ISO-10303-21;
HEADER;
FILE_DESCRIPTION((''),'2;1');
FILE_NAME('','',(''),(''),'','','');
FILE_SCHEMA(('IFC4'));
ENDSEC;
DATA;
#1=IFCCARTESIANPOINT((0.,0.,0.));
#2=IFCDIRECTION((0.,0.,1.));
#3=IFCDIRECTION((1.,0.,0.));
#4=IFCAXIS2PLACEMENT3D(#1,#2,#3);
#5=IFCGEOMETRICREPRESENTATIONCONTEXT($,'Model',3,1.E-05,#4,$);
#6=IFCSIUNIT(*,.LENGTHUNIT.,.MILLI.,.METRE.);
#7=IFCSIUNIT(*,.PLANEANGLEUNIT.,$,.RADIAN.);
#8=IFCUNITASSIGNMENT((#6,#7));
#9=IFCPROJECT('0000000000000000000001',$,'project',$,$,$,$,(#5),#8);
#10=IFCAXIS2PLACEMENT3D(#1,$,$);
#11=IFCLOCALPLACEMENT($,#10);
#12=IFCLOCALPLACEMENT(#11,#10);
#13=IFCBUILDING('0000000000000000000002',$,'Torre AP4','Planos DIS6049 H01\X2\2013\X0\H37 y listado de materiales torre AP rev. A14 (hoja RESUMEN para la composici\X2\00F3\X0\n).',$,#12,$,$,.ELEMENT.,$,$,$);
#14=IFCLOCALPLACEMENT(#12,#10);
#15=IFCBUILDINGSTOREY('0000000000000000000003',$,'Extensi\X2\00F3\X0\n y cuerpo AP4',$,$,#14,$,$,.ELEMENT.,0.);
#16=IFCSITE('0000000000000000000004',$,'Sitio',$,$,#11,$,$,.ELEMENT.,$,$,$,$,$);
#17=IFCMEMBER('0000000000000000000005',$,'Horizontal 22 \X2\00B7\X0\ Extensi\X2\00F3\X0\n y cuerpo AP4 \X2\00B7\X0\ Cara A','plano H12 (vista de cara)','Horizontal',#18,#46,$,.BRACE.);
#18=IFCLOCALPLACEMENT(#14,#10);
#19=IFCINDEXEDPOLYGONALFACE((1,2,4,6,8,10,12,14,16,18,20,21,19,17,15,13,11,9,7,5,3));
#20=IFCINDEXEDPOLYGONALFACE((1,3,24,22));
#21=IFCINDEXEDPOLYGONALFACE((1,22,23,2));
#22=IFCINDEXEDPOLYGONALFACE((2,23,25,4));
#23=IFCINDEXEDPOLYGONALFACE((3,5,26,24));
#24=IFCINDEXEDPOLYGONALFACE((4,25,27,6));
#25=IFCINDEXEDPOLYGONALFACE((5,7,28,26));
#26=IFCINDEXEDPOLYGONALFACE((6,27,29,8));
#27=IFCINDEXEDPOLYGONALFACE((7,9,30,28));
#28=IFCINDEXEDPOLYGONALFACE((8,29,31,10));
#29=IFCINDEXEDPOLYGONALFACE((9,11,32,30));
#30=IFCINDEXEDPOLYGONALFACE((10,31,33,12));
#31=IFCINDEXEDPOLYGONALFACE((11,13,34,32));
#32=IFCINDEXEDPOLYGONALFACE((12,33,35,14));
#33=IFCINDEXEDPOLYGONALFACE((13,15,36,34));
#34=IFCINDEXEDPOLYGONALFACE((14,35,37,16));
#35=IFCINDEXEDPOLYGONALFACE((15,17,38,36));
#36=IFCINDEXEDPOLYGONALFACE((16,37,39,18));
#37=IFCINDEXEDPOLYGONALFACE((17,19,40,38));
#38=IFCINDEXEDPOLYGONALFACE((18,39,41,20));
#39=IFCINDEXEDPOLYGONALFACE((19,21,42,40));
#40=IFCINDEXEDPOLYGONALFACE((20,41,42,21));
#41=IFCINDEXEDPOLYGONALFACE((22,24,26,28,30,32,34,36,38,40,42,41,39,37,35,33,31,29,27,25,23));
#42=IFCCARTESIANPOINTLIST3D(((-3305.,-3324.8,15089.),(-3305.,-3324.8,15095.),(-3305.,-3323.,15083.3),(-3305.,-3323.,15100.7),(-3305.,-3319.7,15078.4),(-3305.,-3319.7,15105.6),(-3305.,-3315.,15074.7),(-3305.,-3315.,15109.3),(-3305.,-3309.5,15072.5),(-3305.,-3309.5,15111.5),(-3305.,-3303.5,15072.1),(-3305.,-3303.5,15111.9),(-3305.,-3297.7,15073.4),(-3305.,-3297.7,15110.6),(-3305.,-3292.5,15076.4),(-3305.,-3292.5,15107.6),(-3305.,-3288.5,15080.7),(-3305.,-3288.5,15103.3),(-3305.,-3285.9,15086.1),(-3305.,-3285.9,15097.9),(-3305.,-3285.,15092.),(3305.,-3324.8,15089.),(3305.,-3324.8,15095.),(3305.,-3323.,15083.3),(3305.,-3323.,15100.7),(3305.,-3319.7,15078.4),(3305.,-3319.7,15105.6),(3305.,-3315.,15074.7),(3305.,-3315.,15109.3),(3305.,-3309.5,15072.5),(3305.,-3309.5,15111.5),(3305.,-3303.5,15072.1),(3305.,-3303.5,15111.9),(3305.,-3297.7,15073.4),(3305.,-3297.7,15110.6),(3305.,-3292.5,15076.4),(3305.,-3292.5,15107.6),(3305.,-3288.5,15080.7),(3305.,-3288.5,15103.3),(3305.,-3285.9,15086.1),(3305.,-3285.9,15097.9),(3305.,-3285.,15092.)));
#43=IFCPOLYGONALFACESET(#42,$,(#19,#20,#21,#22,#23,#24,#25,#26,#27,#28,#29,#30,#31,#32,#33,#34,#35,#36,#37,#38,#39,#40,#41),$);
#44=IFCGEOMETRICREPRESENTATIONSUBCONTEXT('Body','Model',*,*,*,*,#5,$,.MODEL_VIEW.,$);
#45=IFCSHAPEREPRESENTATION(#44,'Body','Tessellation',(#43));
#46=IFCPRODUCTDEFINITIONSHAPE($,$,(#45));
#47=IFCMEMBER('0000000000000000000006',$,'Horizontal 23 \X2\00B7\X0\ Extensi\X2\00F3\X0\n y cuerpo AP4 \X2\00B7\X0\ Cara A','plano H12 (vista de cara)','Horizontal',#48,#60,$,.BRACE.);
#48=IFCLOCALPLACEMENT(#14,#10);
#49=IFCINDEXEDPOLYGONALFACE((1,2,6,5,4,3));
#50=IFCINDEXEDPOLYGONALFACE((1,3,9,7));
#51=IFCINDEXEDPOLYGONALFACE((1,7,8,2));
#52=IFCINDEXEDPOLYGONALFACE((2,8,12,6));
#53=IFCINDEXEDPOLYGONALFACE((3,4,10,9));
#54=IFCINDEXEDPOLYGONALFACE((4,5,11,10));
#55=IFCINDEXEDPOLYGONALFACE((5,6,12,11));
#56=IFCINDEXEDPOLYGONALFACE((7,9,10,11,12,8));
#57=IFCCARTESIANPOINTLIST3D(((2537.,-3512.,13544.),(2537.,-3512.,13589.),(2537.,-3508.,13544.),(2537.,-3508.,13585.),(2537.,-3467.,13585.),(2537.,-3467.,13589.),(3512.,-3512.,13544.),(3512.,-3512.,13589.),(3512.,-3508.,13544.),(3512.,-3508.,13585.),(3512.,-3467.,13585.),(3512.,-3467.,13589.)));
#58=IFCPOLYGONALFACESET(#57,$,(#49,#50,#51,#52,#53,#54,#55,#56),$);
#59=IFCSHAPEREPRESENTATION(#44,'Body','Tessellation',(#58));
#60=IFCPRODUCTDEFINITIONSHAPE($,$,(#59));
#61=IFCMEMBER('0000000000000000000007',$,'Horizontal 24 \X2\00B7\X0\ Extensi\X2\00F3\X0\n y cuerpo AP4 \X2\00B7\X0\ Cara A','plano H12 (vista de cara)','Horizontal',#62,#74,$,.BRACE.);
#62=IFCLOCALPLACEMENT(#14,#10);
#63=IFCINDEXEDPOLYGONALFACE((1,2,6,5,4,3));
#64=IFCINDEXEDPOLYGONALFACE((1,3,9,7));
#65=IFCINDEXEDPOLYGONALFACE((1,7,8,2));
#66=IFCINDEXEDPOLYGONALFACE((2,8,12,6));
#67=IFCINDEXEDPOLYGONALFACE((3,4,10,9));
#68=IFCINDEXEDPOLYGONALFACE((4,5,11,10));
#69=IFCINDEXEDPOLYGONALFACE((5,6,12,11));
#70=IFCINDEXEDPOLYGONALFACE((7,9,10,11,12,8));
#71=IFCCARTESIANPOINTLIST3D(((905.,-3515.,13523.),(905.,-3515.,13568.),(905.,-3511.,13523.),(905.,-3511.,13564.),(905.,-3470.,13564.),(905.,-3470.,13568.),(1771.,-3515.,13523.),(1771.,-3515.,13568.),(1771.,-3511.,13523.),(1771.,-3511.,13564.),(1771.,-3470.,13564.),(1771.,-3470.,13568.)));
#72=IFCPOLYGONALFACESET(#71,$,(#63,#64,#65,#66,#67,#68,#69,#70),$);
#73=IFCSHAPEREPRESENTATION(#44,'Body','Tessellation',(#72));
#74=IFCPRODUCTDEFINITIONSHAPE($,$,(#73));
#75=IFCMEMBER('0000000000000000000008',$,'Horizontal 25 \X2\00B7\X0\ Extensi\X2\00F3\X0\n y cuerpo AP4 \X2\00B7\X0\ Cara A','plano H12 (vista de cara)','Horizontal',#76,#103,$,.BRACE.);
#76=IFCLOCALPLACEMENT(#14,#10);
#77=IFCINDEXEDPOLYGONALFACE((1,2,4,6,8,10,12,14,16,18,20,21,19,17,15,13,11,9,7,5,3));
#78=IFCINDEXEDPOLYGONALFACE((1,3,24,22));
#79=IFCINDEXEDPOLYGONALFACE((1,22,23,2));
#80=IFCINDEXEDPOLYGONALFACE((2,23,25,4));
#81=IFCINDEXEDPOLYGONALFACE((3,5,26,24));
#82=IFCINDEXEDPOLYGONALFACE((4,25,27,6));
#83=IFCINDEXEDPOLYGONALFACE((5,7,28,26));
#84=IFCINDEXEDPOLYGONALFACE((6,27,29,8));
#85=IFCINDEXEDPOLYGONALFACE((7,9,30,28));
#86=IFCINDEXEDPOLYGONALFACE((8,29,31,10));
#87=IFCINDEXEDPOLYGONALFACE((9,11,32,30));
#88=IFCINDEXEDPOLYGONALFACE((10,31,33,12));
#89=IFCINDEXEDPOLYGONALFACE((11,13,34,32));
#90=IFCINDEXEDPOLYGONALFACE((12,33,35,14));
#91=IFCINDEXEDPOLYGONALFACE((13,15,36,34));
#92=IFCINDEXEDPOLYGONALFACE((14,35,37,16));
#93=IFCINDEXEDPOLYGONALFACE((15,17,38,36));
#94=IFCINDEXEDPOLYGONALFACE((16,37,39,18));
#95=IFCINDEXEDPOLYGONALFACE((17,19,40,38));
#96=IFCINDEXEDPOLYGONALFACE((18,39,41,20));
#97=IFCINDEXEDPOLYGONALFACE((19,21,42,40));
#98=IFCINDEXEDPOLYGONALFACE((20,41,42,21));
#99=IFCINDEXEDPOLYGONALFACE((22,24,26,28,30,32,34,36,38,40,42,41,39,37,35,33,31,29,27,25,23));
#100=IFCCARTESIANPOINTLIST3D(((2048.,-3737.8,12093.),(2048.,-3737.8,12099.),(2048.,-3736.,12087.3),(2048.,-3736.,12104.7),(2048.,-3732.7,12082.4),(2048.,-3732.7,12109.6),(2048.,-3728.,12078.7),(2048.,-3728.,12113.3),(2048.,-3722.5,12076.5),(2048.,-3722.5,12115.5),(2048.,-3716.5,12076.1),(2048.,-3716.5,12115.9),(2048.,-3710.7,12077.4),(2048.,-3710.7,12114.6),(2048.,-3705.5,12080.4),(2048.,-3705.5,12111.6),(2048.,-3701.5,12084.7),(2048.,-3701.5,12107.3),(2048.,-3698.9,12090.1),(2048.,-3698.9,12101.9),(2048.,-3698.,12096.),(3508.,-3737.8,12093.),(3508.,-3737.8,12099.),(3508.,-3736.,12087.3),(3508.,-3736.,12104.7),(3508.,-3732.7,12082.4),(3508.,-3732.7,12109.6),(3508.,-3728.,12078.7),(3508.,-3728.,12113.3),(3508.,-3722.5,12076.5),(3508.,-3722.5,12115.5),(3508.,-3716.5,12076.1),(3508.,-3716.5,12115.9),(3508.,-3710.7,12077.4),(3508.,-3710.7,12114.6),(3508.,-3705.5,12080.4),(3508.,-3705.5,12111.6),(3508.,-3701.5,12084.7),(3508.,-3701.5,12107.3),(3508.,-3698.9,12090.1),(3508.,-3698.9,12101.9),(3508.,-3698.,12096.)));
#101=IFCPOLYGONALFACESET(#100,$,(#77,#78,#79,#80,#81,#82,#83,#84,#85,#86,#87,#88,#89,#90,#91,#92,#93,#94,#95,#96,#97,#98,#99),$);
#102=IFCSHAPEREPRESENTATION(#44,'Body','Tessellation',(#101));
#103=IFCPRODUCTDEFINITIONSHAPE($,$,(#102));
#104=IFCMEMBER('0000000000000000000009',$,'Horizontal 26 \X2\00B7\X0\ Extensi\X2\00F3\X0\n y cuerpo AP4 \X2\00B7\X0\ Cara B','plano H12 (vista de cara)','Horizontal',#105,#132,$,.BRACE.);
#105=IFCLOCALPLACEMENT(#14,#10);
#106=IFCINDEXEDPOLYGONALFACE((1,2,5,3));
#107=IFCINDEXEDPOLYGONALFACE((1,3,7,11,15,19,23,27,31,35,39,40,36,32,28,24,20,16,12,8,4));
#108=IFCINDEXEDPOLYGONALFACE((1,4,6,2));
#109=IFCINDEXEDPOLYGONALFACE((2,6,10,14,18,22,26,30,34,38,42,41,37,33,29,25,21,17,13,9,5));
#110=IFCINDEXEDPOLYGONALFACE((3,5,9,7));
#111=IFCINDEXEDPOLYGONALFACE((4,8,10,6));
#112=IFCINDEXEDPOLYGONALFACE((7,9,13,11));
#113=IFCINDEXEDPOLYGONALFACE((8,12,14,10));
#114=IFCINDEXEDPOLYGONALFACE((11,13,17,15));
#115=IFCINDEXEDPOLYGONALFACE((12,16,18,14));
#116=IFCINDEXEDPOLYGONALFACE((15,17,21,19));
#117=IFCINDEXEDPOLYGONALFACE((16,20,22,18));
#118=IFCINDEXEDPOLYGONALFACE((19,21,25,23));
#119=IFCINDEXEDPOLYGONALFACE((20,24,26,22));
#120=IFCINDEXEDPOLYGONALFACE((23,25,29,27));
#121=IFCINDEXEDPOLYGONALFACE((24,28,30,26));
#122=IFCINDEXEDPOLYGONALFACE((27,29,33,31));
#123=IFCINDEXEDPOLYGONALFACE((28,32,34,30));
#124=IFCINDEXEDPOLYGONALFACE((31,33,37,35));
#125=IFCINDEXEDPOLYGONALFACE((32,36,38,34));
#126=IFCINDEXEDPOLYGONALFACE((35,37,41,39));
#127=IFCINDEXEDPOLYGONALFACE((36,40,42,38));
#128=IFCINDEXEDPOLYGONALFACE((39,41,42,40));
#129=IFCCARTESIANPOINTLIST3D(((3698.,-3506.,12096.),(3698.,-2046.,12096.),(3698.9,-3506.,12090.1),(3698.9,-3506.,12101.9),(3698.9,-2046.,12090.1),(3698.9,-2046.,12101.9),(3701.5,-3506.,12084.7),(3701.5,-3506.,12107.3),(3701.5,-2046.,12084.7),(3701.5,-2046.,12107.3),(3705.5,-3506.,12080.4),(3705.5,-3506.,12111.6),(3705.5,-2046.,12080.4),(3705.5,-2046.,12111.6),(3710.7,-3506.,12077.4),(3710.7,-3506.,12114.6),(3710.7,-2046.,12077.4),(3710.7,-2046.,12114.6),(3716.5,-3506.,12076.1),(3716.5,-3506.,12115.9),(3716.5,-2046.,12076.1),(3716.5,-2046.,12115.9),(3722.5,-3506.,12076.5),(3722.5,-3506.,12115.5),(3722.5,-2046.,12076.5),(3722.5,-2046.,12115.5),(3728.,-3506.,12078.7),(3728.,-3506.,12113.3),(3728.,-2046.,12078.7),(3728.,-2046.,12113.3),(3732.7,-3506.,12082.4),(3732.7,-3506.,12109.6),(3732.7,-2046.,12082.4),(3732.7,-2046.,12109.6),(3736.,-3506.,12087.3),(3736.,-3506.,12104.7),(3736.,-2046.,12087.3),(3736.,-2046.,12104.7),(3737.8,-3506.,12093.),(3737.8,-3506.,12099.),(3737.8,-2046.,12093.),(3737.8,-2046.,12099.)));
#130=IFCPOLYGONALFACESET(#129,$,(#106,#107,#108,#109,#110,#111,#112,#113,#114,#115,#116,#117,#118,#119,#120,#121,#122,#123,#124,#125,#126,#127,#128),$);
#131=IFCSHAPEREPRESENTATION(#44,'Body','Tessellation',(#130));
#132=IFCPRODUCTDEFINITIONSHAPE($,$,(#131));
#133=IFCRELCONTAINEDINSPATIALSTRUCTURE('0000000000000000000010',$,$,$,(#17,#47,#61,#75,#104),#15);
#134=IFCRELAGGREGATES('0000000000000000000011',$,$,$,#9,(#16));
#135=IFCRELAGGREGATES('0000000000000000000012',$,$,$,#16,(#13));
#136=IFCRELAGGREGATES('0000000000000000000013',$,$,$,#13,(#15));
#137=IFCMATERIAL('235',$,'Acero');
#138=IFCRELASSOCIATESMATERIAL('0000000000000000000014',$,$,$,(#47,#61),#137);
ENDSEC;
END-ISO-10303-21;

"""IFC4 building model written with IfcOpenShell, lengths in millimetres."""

from ifc_helpers import new_model, si_unit, frame, frame_2d, origin, origin_with_axes, place, context, subcontext, project, spatial, circle, l_section, extrude, material, element, save


model = new_model("IFC4")

# Units and contexts
model_context = context("Model", 3, precision=1e-05, world=origin_with_axes())
body_context = subcontext(model_context, "Body", "Model", "MODEL_VIEW")
ifc_project = project(units=[si_unit("LENGTHUNIT", "METRE", prefix="MILLI"), si_unit("PLANEANGLEUNIT", "RADIAN")], contexts=[model_context])

# Site, building, storey
site_placement = place(None, origin())
site = spatial("IfcSite", under=ifc_project, at=site_placement, Name="Sitio", CompositionType="ELEMENT")
building_placement = place(site_placement, origin())
building = spatial("IfcBuilding", under=site, at=building_placement, Name="Torre AP4", Description="Planos DIS6049 H01–H37 y listado de materiales torre AP rev. A14 (hoja RESUMEN para la composición).", CompositionType="ELEMENT")
storey_placement = place(building_placement, origin())
storey = spatial("IfcBuildingStorey", under=building, at=storey_placement, Name="Extensión y cuerpo AP4", CompositionType="ELEMENT", Elevation=0.0)

# Members
ifc_material_1 = material(Name="235", Category="Acero")
member_1_placement = place(storey_placement, frame((3305.0, -3305.0, 15092.0), z_axis=(-1.0, 0.0, 0.0), x_axis=(0.0, 1.0, 0.0)))
element("IfcMember", 1, at=member_1_placement, inside=storey, Name="Horizontal 22 · Extensión y cuerpo AP4 · Cara A", Description="plano H12 (vista de cara)", ObjectType="Horizontal", PredefinedType="BRACE", context=body_context, shape_type="SweptSolid", body=[
    extrude(circle(Radius=20.0), None, (0.0, 0.0, 1.0), 6610.0),
])
member_2_placement = place(storey_placement, frame((3512.0, -3512.0, 13589.0), z_axis=(-1.0, 0.0, 0.0), x_axis=(0.0, 1.0, 0.0)))
element("IfcMember", 2, at=member_2_placement, inside=storey, material=ifc_material_1, Name="Horizontal 23 · Extensión y cuerpo AP4 · Cara A", Description="plano H12 (vista de cara)", ObjectType="Horizontal", PredefinedType="BRACE", context=body_context, shape_type="SweptSolid", body=[
    extrude(l_section(Depth=45.0, Width=45.0, Thickness=4.0, at=frame_2d((22.5, 22.5))), None, (0.0, 0.0, 1.0), 975.0),
])
member_3_placement = place(storey_placement, frame((1771.0, -3515.0, 13568.0), z_axis=(-1.0, 0.0, 0.0), x_axis=(0.0, 1.0, 0.0)))
element("IfcMember", 3, at=member_3_placement, inside=storey, material=ifc_material_1, Name="Horizontal 24 · Extensión y cuerpo AP4 · Cara A", Description="plano H12 (vista de cara)", ObjectType="Horizontal", PredefinedType="BRACE", context=body_context, shape_type="SweptSolid", body=[
    extrude(l_section(Depth=45.0, Width=45.0, Thickness=4.0, at=frame_2d((22.5, 22.5))), None, (0.0, 0.0, 1.0), 866.0),
])
for number, where, z_axis, x_axis, name in (
    (4, (3508.0, -3718.0, 12096.0), (-1.0, 0.0, 0.0), (0.0, 1.0, 0.0), "Horizontal 25 · Extensión y cuerpo AP4 · Cara A"),
    (5, (3718.0, -2046.0, 12096.0), (0.0, -1.0, 0.0), (-1.0, 0.0, 0.0), "Horizontal 26 · Extensión y cuerpo AP4 · Cara B"),
):
    element("IfcMember", number, at=place(storey_placement, frame(where, z_axis=z_axis, x_axis=x_axis)), inside=storey, Name=name, Description="plano H12 (vista de cara)", ObjectType="Horizontal", PredefinedType="BRACE", context=body_context, shape_type="SweptSolid", body=[
        extrude(circle(Radius=20.0), None, (0.0, 0.0, 1.0), 1460.0),
    ])

save(model, "model.ifc")
